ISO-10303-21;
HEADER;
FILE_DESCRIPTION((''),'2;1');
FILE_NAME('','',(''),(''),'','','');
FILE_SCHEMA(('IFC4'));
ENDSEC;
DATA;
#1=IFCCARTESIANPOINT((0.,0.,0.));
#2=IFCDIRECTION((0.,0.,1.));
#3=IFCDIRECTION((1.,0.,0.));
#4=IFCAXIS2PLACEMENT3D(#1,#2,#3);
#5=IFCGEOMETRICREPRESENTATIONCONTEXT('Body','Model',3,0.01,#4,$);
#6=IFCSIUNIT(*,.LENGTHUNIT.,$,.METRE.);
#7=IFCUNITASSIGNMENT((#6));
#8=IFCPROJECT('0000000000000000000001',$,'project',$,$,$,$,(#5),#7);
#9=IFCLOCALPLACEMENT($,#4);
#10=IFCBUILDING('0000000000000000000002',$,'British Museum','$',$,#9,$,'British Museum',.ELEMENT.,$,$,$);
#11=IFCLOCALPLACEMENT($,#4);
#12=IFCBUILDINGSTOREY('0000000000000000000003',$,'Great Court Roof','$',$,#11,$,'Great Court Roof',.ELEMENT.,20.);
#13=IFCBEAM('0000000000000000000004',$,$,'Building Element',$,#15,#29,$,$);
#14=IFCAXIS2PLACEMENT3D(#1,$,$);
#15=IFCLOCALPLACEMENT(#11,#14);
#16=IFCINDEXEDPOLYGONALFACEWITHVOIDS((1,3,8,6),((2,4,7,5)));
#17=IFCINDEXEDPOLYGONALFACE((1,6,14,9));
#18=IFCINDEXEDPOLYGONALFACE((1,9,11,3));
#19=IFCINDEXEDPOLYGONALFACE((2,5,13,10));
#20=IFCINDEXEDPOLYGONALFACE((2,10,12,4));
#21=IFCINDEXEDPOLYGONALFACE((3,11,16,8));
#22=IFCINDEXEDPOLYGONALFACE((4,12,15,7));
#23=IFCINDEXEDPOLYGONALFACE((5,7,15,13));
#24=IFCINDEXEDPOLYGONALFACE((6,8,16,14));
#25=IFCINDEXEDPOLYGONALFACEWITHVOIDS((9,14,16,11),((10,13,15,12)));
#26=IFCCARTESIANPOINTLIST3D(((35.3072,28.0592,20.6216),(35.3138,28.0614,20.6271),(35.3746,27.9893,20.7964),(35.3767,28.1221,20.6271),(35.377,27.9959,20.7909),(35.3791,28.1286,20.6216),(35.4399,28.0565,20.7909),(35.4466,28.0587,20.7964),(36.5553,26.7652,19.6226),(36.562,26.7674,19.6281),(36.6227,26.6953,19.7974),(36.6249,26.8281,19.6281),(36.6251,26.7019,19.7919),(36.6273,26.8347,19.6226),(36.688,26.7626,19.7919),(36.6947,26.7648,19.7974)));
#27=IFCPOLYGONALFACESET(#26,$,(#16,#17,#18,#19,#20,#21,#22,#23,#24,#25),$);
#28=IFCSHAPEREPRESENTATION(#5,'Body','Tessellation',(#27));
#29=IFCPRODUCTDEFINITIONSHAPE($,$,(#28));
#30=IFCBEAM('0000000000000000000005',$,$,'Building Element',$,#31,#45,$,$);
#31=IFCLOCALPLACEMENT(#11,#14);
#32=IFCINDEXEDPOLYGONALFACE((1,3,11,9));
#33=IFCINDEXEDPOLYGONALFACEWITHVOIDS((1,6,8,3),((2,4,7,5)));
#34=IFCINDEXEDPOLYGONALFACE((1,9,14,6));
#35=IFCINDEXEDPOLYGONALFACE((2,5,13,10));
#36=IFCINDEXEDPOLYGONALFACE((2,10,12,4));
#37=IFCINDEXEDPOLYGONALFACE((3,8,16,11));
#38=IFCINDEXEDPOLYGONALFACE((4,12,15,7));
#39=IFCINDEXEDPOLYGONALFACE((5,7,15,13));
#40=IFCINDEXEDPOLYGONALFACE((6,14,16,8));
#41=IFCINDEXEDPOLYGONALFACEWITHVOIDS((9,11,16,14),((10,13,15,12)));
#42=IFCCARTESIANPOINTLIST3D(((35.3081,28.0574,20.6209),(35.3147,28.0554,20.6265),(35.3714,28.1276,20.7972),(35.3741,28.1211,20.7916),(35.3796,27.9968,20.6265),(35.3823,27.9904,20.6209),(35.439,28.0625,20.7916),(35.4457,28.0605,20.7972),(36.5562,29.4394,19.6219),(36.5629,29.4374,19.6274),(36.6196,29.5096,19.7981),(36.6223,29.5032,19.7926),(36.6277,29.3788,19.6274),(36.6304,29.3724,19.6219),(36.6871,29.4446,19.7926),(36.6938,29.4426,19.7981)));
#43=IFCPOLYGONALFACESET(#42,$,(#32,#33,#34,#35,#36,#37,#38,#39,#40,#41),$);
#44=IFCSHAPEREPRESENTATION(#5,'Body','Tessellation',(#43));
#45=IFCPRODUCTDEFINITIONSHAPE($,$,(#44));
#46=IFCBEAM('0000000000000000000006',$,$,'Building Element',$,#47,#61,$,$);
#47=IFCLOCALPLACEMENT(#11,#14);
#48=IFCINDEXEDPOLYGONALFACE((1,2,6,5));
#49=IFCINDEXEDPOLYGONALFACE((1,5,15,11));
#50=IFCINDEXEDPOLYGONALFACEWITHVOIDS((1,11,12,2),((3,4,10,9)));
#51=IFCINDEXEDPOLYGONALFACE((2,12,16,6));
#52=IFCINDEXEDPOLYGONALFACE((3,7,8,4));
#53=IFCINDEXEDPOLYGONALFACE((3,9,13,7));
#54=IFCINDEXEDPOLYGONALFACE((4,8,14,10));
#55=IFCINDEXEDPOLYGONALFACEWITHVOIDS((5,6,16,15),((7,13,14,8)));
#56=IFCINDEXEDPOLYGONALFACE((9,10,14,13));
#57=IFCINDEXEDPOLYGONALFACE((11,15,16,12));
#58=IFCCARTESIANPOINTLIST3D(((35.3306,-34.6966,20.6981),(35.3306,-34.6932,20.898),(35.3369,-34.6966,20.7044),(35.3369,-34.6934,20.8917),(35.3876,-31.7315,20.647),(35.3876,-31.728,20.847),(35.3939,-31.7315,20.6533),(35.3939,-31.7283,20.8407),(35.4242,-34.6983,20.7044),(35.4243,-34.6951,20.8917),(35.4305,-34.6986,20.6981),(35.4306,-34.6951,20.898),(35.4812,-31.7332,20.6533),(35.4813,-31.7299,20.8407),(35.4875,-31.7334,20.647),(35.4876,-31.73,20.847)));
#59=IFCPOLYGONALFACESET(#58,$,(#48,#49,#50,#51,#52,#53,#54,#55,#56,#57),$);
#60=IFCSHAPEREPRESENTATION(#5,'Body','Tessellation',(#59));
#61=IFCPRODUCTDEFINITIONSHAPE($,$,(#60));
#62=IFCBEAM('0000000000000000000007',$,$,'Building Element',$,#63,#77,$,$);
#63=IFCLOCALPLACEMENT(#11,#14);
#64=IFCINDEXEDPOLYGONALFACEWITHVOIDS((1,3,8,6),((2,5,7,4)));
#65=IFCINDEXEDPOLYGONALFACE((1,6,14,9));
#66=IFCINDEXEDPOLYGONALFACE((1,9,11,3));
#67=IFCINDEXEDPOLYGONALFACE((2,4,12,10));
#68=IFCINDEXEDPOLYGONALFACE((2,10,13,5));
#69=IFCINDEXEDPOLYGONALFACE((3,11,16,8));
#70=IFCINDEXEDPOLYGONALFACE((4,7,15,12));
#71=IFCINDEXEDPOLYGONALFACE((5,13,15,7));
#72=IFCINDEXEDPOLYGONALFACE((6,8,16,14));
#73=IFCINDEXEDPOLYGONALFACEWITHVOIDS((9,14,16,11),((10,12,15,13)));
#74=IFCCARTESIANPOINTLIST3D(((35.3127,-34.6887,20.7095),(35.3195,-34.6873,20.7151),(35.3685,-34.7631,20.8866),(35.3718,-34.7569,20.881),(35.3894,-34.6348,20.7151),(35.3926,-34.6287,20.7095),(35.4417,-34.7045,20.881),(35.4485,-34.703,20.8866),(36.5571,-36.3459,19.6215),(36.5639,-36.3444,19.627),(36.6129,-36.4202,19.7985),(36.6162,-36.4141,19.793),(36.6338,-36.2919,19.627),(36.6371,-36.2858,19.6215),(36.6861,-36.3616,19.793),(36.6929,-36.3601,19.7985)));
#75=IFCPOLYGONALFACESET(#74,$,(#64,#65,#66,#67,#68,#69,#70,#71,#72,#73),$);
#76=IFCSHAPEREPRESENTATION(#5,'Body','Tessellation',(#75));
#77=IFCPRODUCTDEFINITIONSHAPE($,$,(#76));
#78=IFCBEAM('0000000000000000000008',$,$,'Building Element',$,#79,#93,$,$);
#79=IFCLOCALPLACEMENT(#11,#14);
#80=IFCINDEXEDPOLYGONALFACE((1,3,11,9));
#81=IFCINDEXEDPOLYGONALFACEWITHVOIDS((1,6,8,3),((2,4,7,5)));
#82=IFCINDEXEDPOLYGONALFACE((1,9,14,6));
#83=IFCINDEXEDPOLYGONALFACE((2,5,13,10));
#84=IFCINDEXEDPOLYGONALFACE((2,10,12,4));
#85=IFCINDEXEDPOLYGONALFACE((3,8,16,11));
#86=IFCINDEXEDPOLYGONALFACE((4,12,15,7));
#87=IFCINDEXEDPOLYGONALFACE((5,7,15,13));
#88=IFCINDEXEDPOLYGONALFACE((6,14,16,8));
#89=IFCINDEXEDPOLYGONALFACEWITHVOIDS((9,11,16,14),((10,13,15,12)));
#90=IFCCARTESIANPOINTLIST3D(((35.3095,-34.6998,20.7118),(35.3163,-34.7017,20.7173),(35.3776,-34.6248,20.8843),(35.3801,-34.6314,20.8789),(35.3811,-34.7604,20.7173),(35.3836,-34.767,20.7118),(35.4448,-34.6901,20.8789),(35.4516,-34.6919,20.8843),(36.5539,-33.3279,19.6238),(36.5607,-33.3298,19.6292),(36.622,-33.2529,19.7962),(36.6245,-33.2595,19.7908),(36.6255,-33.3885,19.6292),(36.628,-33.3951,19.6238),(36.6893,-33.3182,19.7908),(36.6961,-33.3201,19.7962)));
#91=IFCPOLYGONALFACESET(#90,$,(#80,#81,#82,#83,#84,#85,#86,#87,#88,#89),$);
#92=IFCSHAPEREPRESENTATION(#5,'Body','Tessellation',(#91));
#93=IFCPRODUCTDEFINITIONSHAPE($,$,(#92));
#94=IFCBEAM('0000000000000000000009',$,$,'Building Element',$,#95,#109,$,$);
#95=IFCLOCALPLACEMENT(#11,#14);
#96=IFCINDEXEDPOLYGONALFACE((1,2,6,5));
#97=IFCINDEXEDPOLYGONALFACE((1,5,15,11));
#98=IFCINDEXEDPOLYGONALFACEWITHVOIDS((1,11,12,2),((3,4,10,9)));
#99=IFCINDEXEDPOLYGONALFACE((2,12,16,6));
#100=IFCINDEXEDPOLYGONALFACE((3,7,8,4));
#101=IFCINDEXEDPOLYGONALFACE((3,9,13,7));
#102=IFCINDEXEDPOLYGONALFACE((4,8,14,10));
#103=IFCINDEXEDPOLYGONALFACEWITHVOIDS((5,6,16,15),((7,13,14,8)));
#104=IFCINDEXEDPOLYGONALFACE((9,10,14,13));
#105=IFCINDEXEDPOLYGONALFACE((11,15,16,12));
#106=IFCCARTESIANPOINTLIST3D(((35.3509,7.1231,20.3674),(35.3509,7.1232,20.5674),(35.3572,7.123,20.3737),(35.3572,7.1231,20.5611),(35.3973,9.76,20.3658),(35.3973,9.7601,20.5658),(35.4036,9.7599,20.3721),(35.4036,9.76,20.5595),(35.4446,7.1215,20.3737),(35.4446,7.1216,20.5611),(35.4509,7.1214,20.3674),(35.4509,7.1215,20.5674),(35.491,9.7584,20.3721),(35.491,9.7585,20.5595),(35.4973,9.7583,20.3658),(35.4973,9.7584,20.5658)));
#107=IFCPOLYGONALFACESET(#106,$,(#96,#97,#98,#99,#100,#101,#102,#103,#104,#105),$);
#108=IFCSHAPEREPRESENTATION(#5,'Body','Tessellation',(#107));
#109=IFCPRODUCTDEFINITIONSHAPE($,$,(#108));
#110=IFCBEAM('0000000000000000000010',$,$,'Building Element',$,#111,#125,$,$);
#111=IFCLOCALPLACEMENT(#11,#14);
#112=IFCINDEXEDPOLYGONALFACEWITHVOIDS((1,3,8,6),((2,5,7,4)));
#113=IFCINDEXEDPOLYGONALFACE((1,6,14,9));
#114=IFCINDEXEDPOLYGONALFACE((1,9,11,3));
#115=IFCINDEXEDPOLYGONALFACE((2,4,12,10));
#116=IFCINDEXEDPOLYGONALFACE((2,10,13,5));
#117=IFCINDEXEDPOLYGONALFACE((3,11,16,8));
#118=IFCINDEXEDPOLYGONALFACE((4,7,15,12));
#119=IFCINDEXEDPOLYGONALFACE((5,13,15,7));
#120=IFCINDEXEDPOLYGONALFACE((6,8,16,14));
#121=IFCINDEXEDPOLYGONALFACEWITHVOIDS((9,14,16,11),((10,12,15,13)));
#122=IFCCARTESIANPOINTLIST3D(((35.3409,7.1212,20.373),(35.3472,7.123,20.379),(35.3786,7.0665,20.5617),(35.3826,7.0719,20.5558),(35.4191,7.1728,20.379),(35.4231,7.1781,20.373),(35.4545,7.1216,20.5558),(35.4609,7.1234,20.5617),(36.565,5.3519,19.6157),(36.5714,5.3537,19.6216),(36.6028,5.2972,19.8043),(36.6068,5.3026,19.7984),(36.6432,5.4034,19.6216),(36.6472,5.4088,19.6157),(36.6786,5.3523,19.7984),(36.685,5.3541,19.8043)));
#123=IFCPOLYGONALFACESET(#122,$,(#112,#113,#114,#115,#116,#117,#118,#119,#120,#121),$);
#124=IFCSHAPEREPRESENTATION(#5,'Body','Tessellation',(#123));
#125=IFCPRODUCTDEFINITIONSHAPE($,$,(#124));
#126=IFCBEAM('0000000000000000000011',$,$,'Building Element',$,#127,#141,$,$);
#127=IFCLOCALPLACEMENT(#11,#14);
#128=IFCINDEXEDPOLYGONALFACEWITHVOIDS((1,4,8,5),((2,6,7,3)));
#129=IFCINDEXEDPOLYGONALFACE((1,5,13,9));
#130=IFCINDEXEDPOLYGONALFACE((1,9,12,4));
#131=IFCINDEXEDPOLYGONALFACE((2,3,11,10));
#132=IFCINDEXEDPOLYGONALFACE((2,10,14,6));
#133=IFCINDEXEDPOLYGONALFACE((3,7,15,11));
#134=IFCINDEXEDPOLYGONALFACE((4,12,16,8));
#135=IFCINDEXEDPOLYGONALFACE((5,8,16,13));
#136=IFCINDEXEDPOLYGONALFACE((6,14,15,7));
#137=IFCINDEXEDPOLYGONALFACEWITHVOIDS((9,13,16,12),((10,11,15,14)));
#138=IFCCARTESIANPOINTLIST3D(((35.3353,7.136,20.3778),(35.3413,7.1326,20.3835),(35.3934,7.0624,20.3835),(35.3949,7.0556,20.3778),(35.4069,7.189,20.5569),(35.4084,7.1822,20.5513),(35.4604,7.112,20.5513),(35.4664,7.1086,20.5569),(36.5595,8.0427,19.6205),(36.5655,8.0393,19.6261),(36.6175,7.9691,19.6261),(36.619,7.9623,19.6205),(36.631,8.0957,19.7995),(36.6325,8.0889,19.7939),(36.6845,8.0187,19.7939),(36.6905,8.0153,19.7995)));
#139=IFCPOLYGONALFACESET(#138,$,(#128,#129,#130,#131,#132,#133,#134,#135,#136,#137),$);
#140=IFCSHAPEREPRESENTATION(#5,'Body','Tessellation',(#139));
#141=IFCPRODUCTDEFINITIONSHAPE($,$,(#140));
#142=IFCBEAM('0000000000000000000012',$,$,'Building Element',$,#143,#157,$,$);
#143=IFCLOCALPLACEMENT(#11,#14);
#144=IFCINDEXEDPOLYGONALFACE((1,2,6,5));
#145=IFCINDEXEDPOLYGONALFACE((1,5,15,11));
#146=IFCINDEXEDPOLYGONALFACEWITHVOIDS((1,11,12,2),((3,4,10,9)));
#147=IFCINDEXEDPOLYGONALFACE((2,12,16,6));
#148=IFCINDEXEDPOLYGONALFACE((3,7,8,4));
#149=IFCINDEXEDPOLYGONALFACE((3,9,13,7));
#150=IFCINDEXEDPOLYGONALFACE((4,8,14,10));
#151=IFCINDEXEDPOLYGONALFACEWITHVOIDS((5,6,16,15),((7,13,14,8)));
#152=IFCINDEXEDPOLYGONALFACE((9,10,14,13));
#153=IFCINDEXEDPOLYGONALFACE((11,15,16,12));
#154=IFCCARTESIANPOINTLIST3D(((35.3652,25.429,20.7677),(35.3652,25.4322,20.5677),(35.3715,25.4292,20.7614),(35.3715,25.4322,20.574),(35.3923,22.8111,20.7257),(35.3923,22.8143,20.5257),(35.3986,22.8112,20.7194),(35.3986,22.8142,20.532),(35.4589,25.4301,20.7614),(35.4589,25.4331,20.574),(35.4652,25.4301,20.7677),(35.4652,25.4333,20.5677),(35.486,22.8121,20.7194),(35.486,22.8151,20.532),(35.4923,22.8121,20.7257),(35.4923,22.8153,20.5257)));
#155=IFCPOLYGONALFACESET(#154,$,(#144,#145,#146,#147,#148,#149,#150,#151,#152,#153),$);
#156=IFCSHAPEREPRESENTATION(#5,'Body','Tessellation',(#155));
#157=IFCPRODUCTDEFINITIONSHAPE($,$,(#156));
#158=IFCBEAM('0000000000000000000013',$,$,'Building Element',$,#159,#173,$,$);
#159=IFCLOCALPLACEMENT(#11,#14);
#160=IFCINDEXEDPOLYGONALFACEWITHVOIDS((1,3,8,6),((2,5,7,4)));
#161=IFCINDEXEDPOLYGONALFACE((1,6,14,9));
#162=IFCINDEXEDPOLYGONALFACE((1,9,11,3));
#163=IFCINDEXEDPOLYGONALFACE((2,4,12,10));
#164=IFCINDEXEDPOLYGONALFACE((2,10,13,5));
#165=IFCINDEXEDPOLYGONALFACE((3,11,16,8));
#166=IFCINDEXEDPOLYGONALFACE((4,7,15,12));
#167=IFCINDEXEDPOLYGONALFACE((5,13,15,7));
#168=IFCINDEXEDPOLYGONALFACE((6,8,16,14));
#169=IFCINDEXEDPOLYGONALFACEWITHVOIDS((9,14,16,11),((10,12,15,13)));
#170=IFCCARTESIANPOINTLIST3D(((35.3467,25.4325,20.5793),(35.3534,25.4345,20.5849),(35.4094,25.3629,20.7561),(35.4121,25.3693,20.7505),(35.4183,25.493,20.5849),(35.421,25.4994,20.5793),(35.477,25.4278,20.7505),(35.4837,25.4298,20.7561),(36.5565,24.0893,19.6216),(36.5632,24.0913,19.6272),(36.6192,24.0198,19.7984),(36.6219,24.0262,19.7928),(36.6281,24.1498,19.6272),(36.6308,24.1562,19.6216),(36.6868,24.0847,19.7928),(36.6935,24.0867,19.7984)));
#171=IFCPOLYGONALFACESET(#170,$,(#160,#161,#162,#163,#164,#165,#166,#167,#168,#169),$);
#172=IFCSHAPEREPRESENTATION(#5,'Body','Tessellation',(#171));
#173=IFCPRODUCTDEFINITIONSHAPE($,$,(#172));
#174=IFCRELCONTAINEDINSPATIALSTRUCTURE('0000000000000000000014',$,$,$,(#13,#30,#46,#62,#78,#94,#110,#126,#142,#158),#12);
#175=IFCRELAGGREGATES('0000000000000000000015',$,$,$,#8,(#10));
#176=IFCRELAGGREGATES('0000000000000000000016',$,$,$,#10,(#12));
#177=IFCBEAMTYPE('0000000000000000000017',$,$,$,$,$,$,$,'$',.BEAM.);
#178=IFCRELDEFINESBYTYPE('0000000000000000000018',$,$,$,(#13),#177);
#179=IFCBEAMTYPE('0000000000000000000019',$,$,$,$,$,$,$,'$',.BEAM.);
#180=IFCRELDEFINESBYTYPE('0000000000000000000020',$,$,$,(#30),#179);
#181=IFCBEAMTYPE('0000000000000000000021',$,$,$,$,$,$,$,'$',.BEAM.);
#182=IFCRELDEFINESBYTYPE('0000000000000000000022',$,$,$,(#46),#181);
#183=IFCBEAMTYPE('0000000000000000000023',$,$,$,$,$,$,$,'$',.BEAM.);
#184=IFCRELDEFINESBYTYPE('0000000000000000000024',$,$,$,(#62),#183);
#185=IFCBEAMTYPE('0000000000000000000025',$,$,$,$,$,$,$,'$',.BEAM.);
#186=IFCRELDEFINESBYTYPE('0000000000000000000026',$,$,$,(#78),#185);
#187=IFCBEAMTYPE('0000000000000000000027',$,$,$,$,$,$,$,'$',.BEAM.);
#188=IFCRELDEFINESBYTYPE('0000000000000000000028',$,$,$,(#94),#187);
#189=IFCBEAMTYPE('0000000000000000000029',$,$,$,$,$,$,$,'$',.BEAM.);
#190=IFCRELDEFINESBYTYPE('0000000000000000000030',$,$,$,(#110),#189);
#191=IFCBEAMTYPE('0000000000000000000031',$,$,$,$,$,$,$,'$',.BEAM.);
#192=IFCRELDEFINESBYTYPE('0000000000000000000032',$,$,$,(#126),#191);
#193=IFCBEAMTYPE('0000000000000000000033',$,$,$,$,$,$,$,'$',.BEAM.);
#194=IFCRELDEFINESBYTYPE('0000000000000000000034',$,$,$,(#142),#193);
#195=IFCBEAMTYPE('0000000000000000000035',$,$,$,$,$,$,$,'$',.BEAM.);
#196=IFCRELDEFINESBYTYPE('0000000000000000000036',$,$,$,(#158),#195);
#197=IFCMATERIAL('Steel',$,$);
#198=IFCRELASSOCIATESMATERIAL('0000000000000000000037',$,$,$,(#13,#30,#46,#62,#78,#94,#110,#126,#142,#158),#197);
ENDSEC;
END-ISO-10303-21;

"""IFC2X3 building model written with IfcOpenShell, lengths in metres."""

from ifc_helpers import new_model, si_unit, frame, origin_with_axes, origin_2d, place, context, project, spatial, hollow_rectangle, extrude, material, type_object, element, save


model = new_model("IFC2X3")

# Units and contexts
model_context = context("Model", 3, precision=0.01, world=origin_with_axes(), identifier="Body")
ifc_project = project(units=[si_unit("LENGTHUNIT", "METRE")], contexts=[model_context])

# Building, storey
building_placement = place(None, origin_with_axes())
building = spatial("IfcBuilding", under=ifc_project, at=building_placement, Name="British Museum", Description="$", LongName="British Museum", CompositionType="ELEMENT")
storey_placement = place(None, origin_with_axes())
storey = spatial("IfcBuildingStorey", under=building, at=storey_placement, Name="Great Court Roof", Description="$", LongName="Great Court Roof", CompositionType="ELEMENT", Elevation=20.0)

# Beams
ifc_material = material(Name="Steel")
beam_type_1 = type_object("IfcBeamType", ElementType="$", PredefinedType="BEAM")
beam_1_placement = place(None, origin_with_axes())
element("IfcBeam", 1, at=beam_1_placement, inside=storey, type_object=beam_type_1, material=ifc_material, Description="Building Element", context=model_context, shape_type="SweptSolid", body=[
    extrude(hollow_rectangle(XDim=0.1, YDim=0.2, WallThickness=0.0063, InnerFilletRadius=-0.0063, OuterFilletRadius=0.0, at=origin_2d()), frame((35.3769, 28.059, 20.709), z_axis=(0.606845, -0.629129, -0.485733), x_axis=(0.719738, 0.694245, 0.0)), (0.0, 0.0, 1.0), 2.0568),
])
beam_type_2 = type_object("IfcBeamType", ElementType="$", PredefinedType="BEAM")
beam_2_placement = place(None, origin_with_axes())
element("IfcBeam", 2, at=beam_2_placement, inside=storey, type_object=beam_type_2, material=ifc_material, Description="Building Element", context=model_context, shape_type="SweptSolid", body=[
    extrude(hollow_rectangle(XDim=0.1, YDim=0.2, WallThickness=0.0063, InnerFilletRadius=-0.0063, OuterFilletRadius=0.0, at=origin_2d()), frame((35.3769, 28.059, 20.709), z_axis=(0.590615, 0.65398, -0.472742), x_axis=(-0.742146, 0.670239, 0.0)), (0.0, 0.0, 1.0), 2.1133),
])
beam_type_3 = type_object("IfcBeamType", ElementType="$", PredefinedType="BEAM")
beam_3_placement = place(None, origin_with_axes())
element("IfcBeam", 3, at=beam_3_placement, inside=storey, type_object=beam_type_3, material=ifc_material, Description="Building Element", context=model_context, shape_type="SweptSolid", body=[
    extrude(hollow_rectangle(XDim=0.1, YDim=0.2, WallThickness=0.0063, InnerFilletRadius=-0.0063, OuterFilletRadius=0.0, at=origin_2d()), frame((35.3806, -34.6959, 20.7981), z_axis=(0.019218, 0.999667, -0.017217), x_axis=(-0.999815, 0.019221, 0.0)), (0.0, 0.0, 1.0), 2.9661),
])
beam_type_4 = type_object("IfcBeamType", ElementType="$", PredefinedType="BEAM")
beam_4_placement = place(None, origin_with_axes())
element("IfcBeam", 4, at=beam_4_placement, inside=storey, type_object=beam_type_4, material=ifc_material, Description="Building Element", context=model_context, shape_type="SweptSolid", body=[
    extrude(hollow_rectangle(XDim=0.1, YDim=0.2, WallThickness=0.0063, InnerFilletRadius=-0.0063, OuterFilletRadius=0.0, at=origin_2d()), frame((35.3806, -34.6959, 20.7981), z_axis=(0.531661, -0.707985, -0.46486), x_axis=(0.799636, 0.600486, 0.0)), (0.0, 0.0, 1.0), 2.3406),
])
beam_type_5 = type_object("IfcBeamType", ElementType="$", PredefinedType="BEAM")
beam_5_placement = place(None, origin_with_axes())
element("IfcBeam", 5, at=beam_5_placement, inside=storey, type_object=beam_type_5, material=ifc_material, Description="Building Element", context=model_context, shape_type="SweptSolid", body=[
    extrude(hollow_rectangle(XDim=0.1, YDim=0.2, WallThickness=0.0063, InnerFilletRadius=-0.0063, OuterFilletRadius=0.0, at=origin_2d()), frame((35.3806, -34.6959, 20.7981), z_axis=(0.579301, 0.638633, -0.506515), x_axis=(-0.740675, 0.671863, 0.0)), (0.0, 0.0, 1.0), 2.1481),
])
beam_type_6 = type_object("IfcBeamType", ElementType="$", PredefinedType="BEAM")
beam_6_placement = place(None, origin_with_axes())
element("IfcBeam", 6, at=beam_6_placement, inside=storey, type_object=beam_type_6, material=ifc_material, Description="Building Element", context=model_context, shape_type="SweptSolid", body=[
    extrude(hollow_rectangle(XDim=0.1, YDim=0.2, WallThickness=0.0063, InnerFilletRadius=-0.0063, OuterFilletRadius=0.0, at=origin_2d()), frame((35.4009, 7.1223, 20.4674), z_axis=(0.01761, 0.999845, -0.000584), x_axis=(-0.999845, 0.01761, 0.0)), (0.0, 0.0, 1.0), 2.6373),
])
beam_type_7 = type_object("IfcBeamType", ElementType="$", PredefinedType="BEAM")
beam_7_placement = place(None, origin_with_axes())
element("IfcBeam", 7, at=beam_7_placement, inside=storey, type_object=beam_type_7, material=ifc_material, Description="Building Element", context=model_context, shape_type="SweptSolid", body=[
    extrude(hollow_rectangle(XDim=0.1, YDim=0.2, WallThickness=0.0063, InnerFilletRadius=-0.0063, OuterFilletRadius=0.0, at=origin_2d()), frame((35.4009, 7.1223, 20.4674), z_axis=(0.536686, -0.775702, -0.332047), x_axis=(0.82236, 0.568967, 0.0)), (0.0, 0.0, 1.0), 2.2809),
])
beam_type_8 = type_object("IfcBeamType", ElementType="$", PredefinedType="BEAM")
beam_8_placement = place(None, origin_with_axes())
element("IfcBeam", 8, at=beam_8_placement, inside=storey, type_object=beam_type_8, material=ifc_material, Description="Building Element", context=model_context, shape_type="SweptSolid", body=[
    extrude(hollow_rectangle(XDim=0.1, YDim=0.2, WallThickness=0.0063, InnerFilletRadius=-0.0063, OuterFilletRadius=0.0, at=origin_2d()), frame((35.4009, 7.1223, 20.4674), z_axis=(0.719553, 0.532965, -0.445187), x_axis=(-0.5952, 0.803577, 0.0)), (0.0, 0.0, 1.0), 1.7012),
])
beam_type_9 = type_object("IfcBeamType", ElementType="$", PredefinedType="BEAM")
beam_9_placement = place(None, origin_with_axes())
element("IfcBeam", 9, at=beam_9_placement, inside=storey, type_object=beam_type_9, material=ifc_material, Description="Building Element", context=model_context, shape_type="SweptSolid", body=[
    extrude(hollow_rectangle(XDim=0.1, YDim=0.2, WallThickness=0.0063, InnerFilletRadius=-0.0063, OuterFilletRadius=0.0, at=origin_2d()), frame((35.4152, 25.4312, 20.6677), z_axis=(0.010342, -0.999818, -0.016049), x_axis=(0.999947, 0.010344, 0.0)), (0.0, 0.0, 1.0), 2.6184),
])
beam_type_10 = type_object("IfcBeamType", ElementType="$", PredefinedType="BEAM")
beam_10_placement = place(None, origin_with_axes())
element("IfcBeam", 10, at=beam_10_placement, inside=storey, type_object=beam_type_10, material=ifc_material, Description="Building Element", context=model_context, shape_type="SweptSolid", body=[
    extrude(hollow_rectangle(XDim=0.1, YDim=0.2, WallThickness=0.0063, InnerFilletRadius=-0.0063, OuterFilletRadius=0.0, at=origin_2d()), frame((35.4152, 25.4312, 20.6677), z_axis=(0.591388, -0.656577, -0.468153), x_axis=(0.74303, 0.669258, 0.0)), (0.0, 0.0, 1.0), 2.0457),
])

save(model, "model.ifc")
